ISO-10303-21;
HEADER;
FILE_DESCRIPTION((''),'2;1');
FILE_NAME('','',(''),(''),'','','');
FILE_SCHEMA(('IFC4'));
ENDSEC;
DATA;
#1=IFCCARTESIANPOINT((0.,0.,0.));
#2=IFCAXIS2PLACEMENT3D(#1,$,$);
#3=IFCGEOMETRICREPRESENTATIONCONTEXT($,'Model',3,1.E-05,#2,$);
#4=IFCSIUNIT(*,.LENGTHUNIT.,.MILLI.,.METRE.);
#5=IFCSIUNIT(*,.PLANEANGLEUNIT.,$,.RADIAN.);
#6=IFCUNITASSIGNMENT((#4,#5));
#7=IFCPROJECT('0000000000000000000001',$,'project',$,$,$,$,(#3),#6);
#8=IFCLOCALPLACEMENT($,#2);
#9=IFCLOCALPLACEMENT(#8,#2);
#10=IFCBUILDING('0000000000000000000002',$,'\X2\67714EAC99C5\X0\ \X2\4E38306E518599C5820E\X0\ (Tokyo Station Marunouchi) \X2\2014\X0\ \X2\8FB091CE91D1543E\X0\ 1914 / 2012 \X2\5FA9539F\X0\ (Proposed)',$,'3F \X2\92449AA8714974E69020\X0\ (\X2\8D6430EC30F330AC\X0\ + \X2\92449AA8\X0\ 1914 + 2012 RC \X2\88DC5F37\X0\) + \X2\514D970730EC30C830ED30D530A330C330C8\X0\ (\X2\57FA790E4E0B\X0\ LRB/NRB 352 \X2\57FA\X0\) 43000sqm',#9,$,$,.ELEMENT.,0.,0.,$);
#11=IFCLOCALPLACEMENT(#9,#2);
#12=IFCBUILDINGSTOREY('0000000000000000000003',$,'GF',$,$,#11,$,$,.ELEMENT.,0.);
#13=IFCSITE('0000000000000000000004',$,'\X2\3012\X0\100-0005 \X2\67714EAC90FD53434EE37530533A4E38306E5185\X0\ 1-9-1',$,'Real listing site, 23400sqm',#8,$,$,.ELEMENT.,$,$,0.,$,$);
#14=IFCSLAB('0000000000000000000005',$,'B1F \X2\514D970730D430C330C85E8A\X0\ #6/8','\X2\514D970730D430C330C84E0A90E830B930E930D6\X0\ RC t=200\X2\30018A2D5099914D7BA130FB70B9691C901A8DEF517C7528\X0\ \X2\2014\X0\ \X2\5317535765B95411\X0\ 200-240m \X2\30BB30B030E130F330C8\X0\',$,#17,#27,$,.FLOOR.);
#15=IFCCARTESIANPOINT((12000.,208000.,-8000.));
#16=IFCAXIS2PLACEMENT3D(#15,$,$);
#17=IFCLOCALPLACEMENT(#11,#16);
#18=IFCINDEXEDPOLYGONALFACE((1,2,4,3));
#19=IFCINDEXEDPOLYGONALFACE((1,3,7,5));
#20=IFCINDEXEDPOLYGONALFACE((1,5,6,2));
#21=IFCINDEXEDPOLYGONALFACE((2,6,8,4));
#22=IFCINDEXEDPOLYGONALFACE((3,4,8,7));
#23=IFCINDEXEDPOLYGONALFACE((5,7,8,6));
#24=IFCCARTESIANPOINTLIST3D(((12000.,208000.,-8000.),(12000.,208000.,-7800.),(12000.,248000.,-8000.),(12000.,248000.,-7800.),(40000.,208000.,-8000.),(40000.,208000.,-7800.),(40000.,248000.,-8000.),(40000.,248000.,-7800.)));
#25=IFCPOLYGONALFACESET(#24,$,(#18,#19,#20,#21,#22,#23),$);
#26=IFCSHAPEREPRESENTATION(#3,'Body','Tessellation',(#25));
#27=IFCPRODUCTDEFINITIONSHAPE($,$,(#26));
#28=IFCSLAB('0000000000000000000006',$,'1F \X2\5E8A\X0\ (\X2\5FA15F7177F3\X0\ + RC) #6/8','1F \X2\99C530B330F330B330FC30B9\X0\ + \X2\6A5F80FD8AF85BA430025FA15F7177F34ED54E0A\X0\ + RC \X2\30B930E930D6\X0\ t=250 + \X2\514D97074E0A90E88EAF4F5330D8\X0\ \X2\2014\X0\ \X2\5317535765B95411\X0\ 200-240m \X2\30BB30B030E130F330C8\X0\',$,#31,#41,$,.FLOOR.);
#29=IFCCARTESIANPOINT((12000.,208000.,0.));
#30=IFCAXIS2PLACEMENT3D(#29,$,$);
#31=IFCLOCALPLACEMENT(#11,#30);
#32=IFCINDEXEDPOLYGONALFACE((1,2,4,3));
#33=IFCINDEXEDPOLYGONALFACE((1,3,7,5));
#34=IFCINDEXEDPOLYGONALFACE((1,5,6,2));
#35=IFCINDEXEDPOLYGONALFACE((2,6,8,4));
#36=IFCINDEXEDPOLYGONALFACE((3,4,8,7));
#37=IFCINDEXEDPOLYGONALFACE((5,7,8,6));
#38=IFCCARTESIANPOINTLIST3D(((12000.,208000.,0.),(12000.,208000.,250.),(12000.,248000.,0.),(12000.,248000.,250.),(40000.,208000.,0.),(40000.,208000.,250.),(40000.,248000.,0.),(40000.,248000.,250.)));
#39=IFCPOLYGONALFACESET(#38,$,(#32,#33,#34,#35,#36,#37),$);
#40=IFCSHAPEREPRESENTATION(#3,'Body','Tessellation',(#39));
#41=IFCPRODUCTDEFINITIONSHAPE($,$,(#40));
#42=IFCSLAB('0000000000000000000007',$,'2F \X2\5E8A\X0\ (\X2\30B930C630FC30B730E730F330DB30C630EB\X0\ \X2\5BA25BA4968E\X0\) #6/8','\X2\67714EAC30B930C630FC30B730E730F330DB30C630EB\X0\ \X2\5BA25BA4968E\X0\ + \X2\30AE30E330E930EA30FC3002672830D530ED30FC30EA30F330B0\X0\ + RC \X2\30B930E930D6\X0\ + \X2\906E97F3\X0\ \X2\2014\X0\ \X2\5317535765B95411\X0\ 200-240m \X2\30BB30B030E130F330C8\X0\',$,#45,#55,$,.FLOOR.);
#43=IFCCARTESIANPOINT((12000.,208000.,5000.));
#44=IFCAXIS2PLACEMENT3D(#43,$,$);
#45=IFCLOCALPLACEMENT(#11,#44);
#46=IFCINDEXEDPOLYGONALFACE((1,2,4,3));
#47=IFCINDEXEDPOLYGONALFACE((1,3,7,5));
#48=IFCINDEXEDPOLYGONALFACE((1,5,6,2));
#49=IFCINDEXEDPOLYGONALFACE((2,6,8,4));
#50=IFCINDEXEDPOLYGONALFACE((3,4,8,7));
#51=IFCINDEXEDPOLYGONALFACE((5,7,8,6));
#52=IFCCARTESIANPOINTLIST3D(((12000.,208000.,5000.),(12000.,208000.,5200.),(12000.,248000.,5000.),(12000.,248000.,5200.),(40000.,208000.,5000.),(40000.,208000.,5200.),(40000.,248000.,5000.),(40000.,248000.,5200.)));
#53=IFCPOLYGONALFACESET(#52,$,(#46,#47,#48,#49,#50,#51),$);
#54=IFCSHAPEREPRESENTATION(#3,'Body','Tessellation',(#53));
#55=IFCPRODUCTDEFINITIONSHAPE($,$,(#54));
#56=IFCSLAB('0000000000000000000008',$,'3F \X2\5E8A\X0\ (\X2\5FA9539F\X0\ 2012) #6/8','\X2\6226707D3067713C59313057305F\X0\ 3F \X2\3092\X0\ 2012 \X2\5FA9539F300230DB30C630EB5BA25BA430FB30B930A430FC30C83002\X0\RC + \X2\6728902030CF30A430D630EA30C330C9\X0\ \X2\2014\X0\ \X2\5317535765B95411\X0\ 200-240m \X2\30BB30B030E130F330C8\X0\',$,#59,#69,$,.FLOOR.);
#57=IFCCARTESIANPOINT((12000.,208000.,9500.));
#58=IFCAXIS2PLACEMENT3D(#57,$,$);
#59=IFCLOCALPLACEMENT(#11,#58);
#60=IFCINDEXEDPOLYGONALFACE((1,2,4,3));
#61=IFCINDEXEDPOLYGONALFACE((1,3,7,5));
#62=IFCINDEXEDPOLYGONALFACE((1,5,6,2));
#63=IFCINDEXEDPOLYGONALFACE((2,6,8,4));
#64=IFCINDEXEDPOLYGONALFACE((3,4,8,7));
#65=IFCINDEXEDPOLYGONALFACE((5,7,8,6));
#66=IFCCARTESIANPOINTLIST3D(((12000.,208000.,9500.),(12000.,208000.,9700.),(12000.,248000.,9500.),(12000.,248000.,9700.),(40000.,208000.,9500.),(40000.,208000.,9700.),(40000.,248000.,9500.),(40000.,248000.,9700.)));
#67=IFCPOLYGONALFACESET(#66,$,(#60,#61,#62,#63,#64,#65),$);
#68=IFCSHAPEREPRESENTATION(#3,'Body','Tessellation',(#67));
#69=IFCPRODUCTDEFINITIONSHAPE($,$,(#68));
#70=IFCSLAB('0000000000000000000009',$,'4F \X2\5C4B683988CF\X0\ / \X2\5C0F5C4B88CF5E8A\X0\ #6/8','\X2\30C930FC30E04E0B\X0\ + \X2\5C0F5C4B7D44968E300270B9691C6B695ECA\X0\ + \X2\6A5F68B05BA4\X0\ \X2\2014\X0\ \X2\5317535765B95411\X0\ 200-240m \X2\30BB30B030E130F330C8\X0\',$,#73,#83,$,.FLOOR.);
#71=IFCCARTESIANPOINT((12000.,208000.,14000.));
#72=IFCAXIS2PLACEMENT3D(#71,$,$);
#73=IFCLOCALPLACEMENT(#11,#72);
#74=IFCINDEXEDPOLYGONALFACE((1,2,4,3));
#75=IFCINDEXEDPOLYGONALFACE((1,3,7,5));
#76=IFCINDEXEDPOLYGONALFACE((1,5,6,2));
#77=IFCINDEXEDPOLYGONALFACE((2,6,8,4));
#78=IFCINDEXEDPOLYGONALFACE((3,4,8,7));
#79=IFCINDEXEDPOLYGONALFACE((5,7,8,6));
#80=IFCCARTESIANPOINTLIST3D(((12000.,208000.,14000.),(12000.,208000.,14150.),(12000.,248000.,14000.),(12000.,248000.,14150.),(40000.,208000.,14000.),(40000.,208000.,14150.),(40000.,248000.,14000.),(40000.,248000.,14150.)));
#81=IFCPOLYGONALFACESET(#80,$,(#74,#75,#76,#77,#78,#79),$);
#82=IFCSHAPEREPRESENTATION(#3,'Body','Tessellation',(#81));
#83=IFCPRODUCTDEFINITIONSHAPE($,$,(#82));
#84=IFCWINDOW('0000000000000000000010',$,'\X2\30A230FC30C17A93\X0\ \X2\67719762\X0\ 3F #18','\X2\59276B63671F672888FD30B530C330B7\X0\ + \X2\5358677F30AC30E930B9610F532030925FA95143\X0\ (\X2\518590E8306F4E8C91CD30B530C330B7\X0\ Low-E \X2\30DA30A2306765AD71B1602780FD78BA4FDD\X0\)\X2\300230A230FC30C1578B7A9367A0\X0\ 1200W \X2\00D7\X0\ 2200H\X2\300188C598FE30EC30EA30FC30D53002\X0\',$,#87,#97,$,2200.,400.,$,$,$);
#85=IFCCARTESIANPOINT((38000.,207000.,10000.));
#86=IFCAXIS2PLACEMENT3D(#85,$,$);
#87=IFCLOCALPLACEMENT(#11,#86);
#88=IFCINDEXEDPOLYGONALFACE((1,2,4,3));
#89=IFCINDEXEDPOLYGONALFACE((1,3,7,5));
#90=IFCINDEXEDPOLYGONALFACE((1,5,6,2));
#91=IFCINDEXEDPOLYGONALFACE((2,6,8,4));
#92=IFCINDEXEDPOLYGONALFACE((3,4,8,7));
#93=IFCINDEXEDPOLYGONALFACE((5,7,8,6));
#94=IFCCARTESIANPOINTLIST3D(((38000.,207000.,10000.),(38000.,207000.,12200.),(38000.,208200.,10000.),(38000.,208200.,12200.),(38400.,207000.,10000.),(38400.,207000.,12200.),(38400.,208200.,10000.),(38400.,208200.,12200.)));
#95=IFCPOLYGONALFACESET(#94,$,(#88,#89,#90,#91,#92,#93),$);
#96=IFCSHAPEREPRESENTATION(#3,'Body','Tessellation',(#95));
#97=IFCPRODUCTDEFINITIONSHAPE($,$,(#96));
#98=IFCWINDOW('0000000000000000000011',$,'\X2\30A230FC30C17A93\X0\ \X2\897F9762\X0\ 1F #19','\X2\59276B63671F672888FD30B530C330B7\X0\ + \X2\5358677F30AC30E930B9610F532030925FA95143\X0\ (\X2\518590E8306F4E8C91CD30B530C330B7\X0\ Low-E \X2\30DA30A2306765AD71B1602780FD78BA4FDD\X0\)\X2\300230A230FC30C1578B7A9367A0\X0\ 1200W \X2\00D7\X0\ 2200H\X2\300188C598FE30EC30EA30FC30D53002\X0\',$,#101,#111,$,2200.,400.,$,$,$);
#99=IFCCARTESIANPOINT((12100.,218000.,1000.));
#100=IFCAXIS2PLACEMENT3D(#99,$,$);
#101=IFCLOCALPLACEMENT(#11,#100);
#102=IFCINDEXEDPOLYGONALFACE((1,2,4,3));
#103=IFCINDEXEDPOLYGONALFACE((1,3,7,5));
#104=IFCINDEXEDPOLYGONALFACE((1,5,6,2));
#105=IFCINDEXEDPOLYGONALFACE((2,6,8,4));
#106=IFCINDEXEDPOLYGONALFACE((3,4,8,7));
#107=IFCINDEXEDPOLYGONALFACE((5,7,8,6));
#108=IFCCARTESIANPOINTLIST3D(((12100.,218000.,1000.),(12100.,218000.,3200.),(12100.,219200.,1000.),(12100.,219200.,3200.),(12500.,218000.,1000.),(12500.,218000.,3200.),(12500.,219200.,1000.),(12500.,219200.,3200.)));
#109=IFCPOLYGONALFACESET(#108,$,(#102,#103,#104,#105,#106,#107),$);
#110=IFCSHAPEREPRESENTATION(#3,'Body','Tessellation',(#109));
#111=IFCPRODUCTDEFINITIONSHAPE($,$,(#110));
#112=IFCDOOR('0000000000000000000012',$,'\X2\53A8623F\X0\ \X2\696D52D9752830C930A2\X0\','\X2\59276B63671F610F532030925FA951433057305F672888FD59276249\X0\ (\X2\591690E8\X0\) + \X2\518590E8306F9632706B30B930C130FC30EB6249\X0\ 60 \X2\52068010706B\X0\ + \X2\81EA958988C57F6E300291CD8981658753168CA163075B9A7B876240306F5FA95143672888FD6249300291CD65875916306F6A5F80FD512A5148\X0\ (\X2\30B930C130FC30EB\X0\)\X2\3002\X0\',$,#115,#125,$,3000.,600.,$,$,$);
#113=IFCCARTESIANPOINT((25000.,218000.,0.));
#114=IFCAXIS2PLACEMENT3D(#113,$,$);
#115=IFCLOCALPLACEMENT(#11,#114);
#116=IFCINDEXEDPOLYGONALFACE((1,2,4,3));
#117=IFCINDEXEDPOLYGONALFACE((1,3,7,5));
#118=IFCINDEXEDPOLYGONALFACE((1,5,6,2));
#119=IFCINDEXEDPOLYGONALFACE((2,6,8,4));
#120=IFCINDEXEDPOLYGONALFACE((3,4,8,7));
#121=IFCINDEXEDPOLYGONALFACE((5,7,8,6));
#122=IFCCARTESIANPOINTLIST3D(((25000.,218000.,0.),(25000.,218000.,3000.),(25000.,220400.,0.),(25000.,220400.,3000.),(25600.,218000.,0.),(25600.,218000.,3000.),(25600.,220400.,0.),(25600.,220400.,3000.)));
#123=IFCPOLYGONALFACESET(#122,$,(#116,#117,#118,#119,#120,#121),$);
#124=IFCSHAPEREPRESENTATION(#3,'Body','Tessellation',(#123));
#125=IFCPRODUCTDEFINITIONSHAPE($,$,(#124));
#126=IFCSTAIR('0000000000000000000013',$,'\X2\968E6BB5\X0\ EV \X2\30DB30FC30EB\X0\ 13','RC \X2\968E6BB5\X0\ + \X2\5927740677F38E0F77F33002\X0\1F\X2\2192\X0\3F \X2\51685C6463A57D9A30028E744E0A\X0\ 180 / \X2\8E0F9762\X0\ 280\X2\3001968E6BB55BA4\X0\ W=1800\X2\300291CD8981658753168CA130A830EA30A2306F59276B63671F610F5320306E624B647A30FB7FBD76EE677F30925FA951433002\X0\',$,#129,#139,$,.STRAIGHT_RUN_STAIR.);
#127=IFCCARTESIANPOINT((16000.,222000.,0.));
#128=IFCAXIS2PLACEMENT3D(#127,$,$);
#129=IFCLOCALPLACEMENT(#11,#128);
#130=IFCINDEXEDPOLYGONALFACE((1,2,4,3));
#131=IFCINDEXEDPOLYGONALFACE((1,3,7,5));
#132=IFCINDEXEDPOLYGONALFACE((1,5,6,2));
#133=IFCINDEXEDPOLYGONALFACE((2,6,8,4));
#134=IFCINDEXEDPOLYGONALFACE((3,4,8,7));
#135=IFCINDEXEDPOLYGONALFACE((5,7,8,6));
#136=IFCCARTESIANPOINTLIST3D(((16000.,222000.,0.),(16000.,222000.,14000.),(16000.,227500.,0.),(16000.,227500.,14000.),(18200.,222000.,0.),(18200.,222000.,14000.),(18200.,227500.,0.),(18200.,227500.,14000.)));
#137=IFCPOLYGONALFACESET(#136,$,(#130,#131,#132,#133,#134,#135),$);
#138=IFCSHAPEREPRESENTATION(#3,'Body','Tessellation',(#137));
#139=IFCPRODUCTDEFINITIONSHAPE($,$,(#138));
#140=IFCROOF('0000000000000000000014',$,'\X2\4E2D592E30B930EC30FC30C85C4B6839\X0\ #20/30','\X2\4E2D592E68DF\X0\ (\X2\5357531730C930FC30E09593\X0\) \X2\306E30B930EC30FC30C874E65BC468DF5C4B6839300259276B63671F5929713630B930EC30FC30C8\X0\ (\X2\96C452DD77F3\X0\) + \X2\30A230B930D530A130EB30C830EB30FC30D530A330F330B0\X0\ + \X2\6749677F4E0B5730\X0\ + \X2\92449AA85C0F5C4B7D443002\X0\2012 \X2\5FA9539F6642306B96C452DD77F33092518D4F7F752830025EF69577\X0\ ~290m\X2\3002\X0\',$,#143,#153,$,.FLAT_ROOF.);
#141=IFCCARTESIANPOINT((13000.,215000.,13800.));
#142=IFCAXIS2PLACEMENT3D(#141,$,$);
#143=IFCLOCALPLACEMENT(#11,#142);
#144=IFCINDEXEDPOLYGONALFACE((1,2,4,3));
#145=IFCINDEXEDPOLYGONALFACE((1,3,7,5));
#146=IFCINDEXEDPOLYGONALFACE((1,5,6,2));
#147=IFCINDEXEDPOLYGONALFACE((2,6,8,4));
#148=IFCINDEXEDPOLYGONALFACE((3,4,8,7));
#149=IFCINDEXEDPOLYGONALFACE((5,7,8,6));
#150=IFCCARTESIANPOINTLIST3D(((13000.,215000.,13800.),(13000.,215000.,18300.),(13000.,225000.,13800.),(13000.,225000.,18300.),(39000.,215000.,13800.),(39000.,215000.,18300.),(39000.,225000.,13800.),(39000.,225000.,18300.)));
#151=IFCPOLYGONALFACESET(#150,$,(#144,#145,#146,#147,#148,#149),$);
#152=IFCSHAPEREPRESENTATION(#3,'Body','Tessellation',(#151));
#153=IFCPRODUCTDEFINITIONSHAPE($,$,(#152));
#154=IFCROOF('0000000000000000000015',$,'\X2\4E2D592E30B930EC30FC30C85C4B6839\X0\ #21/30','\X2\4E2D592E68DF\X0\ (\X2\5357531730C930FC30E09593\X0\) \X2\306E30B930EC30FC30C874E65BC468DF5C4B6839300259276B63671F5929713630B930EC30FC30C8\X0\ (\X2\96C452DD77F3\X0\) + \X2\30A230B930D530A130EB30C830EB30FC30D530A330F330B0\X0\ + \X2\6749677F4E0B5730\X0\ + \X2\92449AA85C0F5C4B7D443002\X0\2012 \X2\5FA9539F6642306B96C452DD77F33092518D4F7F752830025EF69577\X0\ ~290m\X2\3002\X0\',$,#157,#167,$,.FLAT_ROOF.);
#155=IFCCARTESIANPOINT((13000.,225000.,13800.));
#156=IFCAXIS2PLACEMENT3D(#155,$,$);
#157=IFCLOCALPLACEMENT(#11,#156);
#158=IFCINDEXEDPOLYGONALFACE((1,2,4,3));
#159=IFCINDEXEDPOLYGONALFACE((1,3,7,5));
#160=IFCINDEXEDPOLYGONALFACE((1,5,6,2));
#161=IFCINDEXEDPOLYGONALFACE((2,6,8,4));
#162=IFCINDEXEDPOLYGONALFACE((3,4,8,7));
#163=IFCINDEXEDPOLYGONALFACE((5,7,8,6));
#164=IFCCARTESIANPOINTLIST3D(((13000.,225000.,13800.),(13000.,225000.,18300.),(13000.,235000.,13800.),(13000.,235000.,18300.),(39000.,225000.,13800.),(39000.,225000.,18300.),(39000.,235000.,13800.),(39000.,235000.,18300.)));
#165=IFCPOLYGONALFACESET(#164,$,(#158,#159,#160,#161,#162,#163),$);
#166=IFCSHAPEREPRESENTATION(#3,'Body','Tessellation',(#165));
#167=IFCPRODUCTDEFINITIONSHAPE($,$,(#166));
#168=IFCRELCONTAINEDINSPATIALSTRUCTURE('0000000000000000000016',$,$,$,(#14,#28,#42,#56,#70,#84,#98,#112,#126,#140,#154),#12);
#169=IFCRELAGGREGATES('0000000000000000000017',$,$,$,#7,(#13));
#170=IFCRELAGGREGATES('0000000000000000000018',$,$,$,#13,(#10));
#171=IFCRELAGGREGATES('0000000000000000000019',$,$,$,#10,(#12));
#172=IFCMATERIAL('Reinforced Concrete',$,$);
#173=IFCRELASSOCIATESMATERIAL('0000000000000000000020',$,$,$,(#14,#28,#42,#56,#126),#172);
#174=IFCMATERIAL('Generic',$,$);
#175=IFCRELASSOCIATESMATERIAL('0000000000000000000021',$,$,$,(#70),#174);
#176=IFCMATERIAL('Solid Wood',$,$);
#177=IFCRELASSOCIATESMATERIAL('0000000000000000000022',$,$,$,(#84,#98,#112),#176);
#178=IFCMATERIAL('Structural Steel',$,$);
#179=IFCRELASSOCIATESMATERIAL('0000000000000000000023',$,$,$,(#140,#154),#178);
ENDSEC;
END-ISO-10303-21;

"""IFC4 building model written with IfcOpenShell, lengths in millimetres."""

from ifc_helpers import new_model, si_unit, frame, frame_2d, origin, place, context, project, spatial, rectangle, extrude, material, element, save


model = new_model("IFC4")

# Units and contexts
model_context = context("Model", 3, precision=1e-05, world=origin())
ifc_project = project(units=[si_unit("LENGTHUNIT", "METRE", prefix="MILLI"), si_unit("PLANEANGLEUNIT", "RADIAN")], contexts=[model_context])

# Site, building, storey
site_placement = place(None, origin())
site = spatial("IfcSite", under=ifc_project, at=site_placement, Name="〒100-0005 東京都千代田区丸の内 1-9-1", ObjectType="Real listing site, 23400sqm", CompositionType="ELEMENT", RefElevation=0.0)
building_placement = place(site_placement, origin())
building = spatial("IfcBuilding", under=site, at=building_placement, Name="東京駅 丸の内駅舎 (Tokyo Station Marunouchi) — 辰野金吾 1914 / 2012 復原 (Proposed)", ObjectType="3F 鉄骨煉瓦造 (赤レンガ + 鉄骨 1914 + 2012 RC 補強) + 免震レトロフィット (基礎下 LRB/NRB 352 基) 43000sqm", CompositionType="ELEMENT", ElevationOfRefHeight=0.0, ElevationOfTerrain=0.0)
storey_placement = place(building_placement, origin())
storey = spatial("IfcBuildingStorey", under=building, at=storey_placement, Name="GF", CompositionType="ELEMENT", Elevation=0.0)

# Shared definitions
ifc_material_1 = material(Name="Reinforced Concrete")

# Shared definitions
ifc_material_2 = material(Name="Structural Steel")

# Slabs
slab_1_placement = place(storey_placement, frame((12000.0, 208000.0, -8000.0)))
element("IfcSlab", 1, at=slab_1_placement, inside=storey, material=ifc_material_1, Name="B1F 免震ピット床 #6/8", Description="免震ピット上部スラブ RC t=200、設備配管・点検通路兼用 — 北南方向 200-240m セグメント", PredefinedType="FLOOR", context=model_context, shape_type="SweptSolid", body=[
    extrude(rectangle(XDim=28000.0, YDim=40000.0, at=frame_2d((14000.0, 20000.0))), frame((12000.0, 208000.0, -8000.0)), (0.0, 0.0, 1.0), 200.0),
])
slab_2_placement = place(storey_placement, frame((12000.0, 208000.0, 0.0)))
element("IfcSlab", 2, at=slab_2_placement, inside=storey, material=ifc_material_1, Name="1F 床 (御影石 + RC) #6/8", Description="1F 駅コンコース + 機能諸室。御影石仕上 + RC スラブ t=250 + 免震上部躯体ヘ — 北南方向 200-240m セグメント", PredefinedType="FLOOR", context=model_context, shape_type="SweptSolid", body=[
    extrude(rectangle(XDim=28000.0, YDim=40000.0, at=frame_2d((14000.0, 20000.0))), frame((12000.0, 208000.0, 0.0)), (0.0, 0.0, 1.0), 250.0),
])
slab_3_placement = place(storey_placement, frame((12000.0, 208000.0, 5000.0)))
element("IfcSlab", 3, at=slab_3_placement, inside=storey, material=ifc_material_1, Name="2F 床 (ステーションホテル 客室階) #6/8", Description="東京ステーションホテル 客室階 + ギャラリー。木フローリング + RC スラブ + 遮音 — 北南方向 200-240m セグメント", PredefinedType="FLOOR", context=model_context, shape_type="SweptSolid", body=[
    extrude(rectangle(XDim=28000.0, YDim=40000.0, at=frame_2d((14000.0, 20000.0))), frame((12000.0, 208000.0, 5000.0)), (0.0, 0.0, 1.0), 200.0),
])
slab_4_placement = place(storey_placement, frame((12000.0, 208000.0, 9500.0)))
element("IfcSlab", 4, at=slab_4_placement, inside=storey, material=ifc_material_1, Name="3F 床 (復原 2012) #6/8", Description="戦災で焼失した 3F を 2012 復原。ホテル客室・スイート。RC + 木造ハイブリッド — 北南方向 200-240m セグメント", PredefinedType="FLOOR", context=model_context, shape_type="SweptSolid", body=[
    extrude(rectangle(XDim=28000.0, YDim=40000.0, at=frame_2d((14000.0, 20000.0))), frame((12000.0, 208000.0, 9500.0)), (0.0, 0.0, 1.0), 200.0),
])
ifc_material_3 = material(Name="Generic")
slab_5_placement = place(storey_placement, frame((12000.0, 208000.0, 14000.0)))
element("IfcSlab", 5, at=slab_5_placement, inside=storey, material=ifc_material_3, Name="4F 屋根裏 / 小屋裏床 #6/8", Description="ドーム下 + 小屋組階。点検歩廊 + 機械室 — 北南方向 200-240m セグメント", PredefinedType="FLOOR", context=model_context, shape_type="SweptSolid", body=[
    extrude(rectangle(XDim=28000.0, YDim=40000.0, at=frame_2d((14000.0, 20000.0))), frame((12000.0, 208000.0, 14000.0)), (0.0, 0.0, 1.0), 150.0),
])

# Windows
ifc_material_4 = material(Name="Solid Wood")
window_1_placement = place(storey_placement, frame((38000.0, 207000.0, 10000.0)))
element("IfcWindow", 6, at=window_1_placement, inside=storey, material=ifc_material_4, Name="アーチ窓 東面 3F #18", Description="大正期木製サッシ + 単板ガラス意匠を復元 (内部は二重サッシ Low-E ペアで断熱性能確保)。アーチ型窓枠 1200W × 2200H、装飾レリーフ。", OverallHeight=2200.0, OverallWidth=400.0, context=model_context, shape_type="SweptSolid", body=[
    extrude(rectangle(XDim=400.0, YDim=1200.0, at=frame_2d((200.0, 600.0))), frame((38000.0, 207000.0, 10000.0)), (0.0, 0.0, 1.0), 2200.0),
])
window_2_placement = place(storey_placement, frame((12100.0, 218000.0, 1000.0)))
element("IfcWindow", 7, at=window_2_placement, inside=storey, material=ifc_material_4, Name="アーチ窓 西面 1F #19", Description="大正期木製サッシ + 単板ガラス意匠を復元 (内部は二重サッシ Low-E ペアで断熱性能確保)。アーチ型窓枠 1200W × 2200H、装飾レリーフ。", OverallHeight=2200.0, OverallWidth=400.0, context=model_context, shape_type="SweptSolid", body=[
    extrude(rectangle(XDim=400.0, YDim=1200.0, at=frame_2d((200.0, 600.0))), frame((12100.0, 218000.0, 1000.0)), (0.0, 0.0, 1.0), 2200.0),
])

# Door
door_placement = place(storey_placement, frame((25000.0, 218000.0, 0.0)))
element("IfcDoor", 8, at=door_placement, inside=storey, material=ifc_material_4, Name="厨房 業務用ドア", Description="大正期意匠を復元した木製大扉 (外部) + 内部は防火スチール扉 60 分耐火 + 自閉装置。重要文化財指定箇所は復元木製扉。重文外は機能優先 (スチール)。", OverallHeight=3000.0, OverallWidth=600.0, context=model_context, shape_type="SweptSolid", body=[
    extrude(rectangle(XDim=600.0, YDim=2400.0, at=frame_2d((300.0, 1200.0))), frame((25000.0, 218000.0, 0.0)), (0.0, 0.0, 1.0), 3000.0),
])

# Stair
stair_placement = place(storey_placement, frame((16000.0, 222000.0, 0.0)))
element("IfcStair", 9, at=stair_placement, inside=storey, material=ifc_material_1, Name="階段 EV ホール 13", Description="RC 階段 + 大理石踏石。1F→3F 全層接続。蹴上 180 / 踏面 280、階段室 W=1800。重要文化財エリアは大正期意匠の手摺・羽目板を復元。", PredefinedType="STRAIGHT_RUN_STAIR", context=model_context, shape_type="SweptSolid", body=[
    extrude(rectangle(XDim=2200.0, YDim=5500.0, at=frame_2d((1100.0, 2750.0))), frame((16000.0, 222000.0, 0.0)), (0.0, 0.0, 1.0), 14000.0),
])

# Roofs
roof_1_placement = place(storey_placement, frame((13000.0, 215000.0, 13800.0)))
element("IfcRoof", 10, at=roof_1_placement, inside=storey, material=ifc_material_2, Name="中央スレート屋根 #20/30", Description="中央棟 (南北ドーム間) のスレート瓦寄棟屋根。大正期天然スレート (雄勝石) + アスファルトルーフィング + 杉板下地 + 鉄骨小屋組。2012 復原時に雄勝石を再使用。延長 ~290m。", PredefinedType="FLAT_ROOF", context=model_context, shape_type="SweptSolid", body=[
    extrude(rectangle(XDim=26000.0, YDim=10000.0, at=frame_2d((13000.0, 5000.0))), frame((13000.0, 215000.0, 13800.0)), (0.0, 0.0, 1.0), 4500.0),
])
roof_2_placement = place(storey_placement, frame((13000.0, 225000.0, 13800.0)))
element("IfcRoof", 11, at=roof_2_placement, inside=storey, material=ifc_material_2, Name="中央スレート屋根 #21/30", Description="中央棟 (南北ドーム間) のスレート瓦寄棟屋根。大正期天然スレート (雄勝石) + アスファルトルーフィング + 杉板下地 + 鉄骨小屋組。2012 復原時に雄勝石を再使用。延長 ~290m。", PredefinedType="FLAT_ROOF", context=model_context, shape_type="SweptSolid", body=[
    extrude(rectangle(XDim=26000.0, YDim=10000.0, at=frame_2d((13000.0, 5000.0))), frame((13000.0, 225000.0, 13800.0)), (0.0, 0.0, 1.0), 4500.0),
])

save(model, "model.ifc")
